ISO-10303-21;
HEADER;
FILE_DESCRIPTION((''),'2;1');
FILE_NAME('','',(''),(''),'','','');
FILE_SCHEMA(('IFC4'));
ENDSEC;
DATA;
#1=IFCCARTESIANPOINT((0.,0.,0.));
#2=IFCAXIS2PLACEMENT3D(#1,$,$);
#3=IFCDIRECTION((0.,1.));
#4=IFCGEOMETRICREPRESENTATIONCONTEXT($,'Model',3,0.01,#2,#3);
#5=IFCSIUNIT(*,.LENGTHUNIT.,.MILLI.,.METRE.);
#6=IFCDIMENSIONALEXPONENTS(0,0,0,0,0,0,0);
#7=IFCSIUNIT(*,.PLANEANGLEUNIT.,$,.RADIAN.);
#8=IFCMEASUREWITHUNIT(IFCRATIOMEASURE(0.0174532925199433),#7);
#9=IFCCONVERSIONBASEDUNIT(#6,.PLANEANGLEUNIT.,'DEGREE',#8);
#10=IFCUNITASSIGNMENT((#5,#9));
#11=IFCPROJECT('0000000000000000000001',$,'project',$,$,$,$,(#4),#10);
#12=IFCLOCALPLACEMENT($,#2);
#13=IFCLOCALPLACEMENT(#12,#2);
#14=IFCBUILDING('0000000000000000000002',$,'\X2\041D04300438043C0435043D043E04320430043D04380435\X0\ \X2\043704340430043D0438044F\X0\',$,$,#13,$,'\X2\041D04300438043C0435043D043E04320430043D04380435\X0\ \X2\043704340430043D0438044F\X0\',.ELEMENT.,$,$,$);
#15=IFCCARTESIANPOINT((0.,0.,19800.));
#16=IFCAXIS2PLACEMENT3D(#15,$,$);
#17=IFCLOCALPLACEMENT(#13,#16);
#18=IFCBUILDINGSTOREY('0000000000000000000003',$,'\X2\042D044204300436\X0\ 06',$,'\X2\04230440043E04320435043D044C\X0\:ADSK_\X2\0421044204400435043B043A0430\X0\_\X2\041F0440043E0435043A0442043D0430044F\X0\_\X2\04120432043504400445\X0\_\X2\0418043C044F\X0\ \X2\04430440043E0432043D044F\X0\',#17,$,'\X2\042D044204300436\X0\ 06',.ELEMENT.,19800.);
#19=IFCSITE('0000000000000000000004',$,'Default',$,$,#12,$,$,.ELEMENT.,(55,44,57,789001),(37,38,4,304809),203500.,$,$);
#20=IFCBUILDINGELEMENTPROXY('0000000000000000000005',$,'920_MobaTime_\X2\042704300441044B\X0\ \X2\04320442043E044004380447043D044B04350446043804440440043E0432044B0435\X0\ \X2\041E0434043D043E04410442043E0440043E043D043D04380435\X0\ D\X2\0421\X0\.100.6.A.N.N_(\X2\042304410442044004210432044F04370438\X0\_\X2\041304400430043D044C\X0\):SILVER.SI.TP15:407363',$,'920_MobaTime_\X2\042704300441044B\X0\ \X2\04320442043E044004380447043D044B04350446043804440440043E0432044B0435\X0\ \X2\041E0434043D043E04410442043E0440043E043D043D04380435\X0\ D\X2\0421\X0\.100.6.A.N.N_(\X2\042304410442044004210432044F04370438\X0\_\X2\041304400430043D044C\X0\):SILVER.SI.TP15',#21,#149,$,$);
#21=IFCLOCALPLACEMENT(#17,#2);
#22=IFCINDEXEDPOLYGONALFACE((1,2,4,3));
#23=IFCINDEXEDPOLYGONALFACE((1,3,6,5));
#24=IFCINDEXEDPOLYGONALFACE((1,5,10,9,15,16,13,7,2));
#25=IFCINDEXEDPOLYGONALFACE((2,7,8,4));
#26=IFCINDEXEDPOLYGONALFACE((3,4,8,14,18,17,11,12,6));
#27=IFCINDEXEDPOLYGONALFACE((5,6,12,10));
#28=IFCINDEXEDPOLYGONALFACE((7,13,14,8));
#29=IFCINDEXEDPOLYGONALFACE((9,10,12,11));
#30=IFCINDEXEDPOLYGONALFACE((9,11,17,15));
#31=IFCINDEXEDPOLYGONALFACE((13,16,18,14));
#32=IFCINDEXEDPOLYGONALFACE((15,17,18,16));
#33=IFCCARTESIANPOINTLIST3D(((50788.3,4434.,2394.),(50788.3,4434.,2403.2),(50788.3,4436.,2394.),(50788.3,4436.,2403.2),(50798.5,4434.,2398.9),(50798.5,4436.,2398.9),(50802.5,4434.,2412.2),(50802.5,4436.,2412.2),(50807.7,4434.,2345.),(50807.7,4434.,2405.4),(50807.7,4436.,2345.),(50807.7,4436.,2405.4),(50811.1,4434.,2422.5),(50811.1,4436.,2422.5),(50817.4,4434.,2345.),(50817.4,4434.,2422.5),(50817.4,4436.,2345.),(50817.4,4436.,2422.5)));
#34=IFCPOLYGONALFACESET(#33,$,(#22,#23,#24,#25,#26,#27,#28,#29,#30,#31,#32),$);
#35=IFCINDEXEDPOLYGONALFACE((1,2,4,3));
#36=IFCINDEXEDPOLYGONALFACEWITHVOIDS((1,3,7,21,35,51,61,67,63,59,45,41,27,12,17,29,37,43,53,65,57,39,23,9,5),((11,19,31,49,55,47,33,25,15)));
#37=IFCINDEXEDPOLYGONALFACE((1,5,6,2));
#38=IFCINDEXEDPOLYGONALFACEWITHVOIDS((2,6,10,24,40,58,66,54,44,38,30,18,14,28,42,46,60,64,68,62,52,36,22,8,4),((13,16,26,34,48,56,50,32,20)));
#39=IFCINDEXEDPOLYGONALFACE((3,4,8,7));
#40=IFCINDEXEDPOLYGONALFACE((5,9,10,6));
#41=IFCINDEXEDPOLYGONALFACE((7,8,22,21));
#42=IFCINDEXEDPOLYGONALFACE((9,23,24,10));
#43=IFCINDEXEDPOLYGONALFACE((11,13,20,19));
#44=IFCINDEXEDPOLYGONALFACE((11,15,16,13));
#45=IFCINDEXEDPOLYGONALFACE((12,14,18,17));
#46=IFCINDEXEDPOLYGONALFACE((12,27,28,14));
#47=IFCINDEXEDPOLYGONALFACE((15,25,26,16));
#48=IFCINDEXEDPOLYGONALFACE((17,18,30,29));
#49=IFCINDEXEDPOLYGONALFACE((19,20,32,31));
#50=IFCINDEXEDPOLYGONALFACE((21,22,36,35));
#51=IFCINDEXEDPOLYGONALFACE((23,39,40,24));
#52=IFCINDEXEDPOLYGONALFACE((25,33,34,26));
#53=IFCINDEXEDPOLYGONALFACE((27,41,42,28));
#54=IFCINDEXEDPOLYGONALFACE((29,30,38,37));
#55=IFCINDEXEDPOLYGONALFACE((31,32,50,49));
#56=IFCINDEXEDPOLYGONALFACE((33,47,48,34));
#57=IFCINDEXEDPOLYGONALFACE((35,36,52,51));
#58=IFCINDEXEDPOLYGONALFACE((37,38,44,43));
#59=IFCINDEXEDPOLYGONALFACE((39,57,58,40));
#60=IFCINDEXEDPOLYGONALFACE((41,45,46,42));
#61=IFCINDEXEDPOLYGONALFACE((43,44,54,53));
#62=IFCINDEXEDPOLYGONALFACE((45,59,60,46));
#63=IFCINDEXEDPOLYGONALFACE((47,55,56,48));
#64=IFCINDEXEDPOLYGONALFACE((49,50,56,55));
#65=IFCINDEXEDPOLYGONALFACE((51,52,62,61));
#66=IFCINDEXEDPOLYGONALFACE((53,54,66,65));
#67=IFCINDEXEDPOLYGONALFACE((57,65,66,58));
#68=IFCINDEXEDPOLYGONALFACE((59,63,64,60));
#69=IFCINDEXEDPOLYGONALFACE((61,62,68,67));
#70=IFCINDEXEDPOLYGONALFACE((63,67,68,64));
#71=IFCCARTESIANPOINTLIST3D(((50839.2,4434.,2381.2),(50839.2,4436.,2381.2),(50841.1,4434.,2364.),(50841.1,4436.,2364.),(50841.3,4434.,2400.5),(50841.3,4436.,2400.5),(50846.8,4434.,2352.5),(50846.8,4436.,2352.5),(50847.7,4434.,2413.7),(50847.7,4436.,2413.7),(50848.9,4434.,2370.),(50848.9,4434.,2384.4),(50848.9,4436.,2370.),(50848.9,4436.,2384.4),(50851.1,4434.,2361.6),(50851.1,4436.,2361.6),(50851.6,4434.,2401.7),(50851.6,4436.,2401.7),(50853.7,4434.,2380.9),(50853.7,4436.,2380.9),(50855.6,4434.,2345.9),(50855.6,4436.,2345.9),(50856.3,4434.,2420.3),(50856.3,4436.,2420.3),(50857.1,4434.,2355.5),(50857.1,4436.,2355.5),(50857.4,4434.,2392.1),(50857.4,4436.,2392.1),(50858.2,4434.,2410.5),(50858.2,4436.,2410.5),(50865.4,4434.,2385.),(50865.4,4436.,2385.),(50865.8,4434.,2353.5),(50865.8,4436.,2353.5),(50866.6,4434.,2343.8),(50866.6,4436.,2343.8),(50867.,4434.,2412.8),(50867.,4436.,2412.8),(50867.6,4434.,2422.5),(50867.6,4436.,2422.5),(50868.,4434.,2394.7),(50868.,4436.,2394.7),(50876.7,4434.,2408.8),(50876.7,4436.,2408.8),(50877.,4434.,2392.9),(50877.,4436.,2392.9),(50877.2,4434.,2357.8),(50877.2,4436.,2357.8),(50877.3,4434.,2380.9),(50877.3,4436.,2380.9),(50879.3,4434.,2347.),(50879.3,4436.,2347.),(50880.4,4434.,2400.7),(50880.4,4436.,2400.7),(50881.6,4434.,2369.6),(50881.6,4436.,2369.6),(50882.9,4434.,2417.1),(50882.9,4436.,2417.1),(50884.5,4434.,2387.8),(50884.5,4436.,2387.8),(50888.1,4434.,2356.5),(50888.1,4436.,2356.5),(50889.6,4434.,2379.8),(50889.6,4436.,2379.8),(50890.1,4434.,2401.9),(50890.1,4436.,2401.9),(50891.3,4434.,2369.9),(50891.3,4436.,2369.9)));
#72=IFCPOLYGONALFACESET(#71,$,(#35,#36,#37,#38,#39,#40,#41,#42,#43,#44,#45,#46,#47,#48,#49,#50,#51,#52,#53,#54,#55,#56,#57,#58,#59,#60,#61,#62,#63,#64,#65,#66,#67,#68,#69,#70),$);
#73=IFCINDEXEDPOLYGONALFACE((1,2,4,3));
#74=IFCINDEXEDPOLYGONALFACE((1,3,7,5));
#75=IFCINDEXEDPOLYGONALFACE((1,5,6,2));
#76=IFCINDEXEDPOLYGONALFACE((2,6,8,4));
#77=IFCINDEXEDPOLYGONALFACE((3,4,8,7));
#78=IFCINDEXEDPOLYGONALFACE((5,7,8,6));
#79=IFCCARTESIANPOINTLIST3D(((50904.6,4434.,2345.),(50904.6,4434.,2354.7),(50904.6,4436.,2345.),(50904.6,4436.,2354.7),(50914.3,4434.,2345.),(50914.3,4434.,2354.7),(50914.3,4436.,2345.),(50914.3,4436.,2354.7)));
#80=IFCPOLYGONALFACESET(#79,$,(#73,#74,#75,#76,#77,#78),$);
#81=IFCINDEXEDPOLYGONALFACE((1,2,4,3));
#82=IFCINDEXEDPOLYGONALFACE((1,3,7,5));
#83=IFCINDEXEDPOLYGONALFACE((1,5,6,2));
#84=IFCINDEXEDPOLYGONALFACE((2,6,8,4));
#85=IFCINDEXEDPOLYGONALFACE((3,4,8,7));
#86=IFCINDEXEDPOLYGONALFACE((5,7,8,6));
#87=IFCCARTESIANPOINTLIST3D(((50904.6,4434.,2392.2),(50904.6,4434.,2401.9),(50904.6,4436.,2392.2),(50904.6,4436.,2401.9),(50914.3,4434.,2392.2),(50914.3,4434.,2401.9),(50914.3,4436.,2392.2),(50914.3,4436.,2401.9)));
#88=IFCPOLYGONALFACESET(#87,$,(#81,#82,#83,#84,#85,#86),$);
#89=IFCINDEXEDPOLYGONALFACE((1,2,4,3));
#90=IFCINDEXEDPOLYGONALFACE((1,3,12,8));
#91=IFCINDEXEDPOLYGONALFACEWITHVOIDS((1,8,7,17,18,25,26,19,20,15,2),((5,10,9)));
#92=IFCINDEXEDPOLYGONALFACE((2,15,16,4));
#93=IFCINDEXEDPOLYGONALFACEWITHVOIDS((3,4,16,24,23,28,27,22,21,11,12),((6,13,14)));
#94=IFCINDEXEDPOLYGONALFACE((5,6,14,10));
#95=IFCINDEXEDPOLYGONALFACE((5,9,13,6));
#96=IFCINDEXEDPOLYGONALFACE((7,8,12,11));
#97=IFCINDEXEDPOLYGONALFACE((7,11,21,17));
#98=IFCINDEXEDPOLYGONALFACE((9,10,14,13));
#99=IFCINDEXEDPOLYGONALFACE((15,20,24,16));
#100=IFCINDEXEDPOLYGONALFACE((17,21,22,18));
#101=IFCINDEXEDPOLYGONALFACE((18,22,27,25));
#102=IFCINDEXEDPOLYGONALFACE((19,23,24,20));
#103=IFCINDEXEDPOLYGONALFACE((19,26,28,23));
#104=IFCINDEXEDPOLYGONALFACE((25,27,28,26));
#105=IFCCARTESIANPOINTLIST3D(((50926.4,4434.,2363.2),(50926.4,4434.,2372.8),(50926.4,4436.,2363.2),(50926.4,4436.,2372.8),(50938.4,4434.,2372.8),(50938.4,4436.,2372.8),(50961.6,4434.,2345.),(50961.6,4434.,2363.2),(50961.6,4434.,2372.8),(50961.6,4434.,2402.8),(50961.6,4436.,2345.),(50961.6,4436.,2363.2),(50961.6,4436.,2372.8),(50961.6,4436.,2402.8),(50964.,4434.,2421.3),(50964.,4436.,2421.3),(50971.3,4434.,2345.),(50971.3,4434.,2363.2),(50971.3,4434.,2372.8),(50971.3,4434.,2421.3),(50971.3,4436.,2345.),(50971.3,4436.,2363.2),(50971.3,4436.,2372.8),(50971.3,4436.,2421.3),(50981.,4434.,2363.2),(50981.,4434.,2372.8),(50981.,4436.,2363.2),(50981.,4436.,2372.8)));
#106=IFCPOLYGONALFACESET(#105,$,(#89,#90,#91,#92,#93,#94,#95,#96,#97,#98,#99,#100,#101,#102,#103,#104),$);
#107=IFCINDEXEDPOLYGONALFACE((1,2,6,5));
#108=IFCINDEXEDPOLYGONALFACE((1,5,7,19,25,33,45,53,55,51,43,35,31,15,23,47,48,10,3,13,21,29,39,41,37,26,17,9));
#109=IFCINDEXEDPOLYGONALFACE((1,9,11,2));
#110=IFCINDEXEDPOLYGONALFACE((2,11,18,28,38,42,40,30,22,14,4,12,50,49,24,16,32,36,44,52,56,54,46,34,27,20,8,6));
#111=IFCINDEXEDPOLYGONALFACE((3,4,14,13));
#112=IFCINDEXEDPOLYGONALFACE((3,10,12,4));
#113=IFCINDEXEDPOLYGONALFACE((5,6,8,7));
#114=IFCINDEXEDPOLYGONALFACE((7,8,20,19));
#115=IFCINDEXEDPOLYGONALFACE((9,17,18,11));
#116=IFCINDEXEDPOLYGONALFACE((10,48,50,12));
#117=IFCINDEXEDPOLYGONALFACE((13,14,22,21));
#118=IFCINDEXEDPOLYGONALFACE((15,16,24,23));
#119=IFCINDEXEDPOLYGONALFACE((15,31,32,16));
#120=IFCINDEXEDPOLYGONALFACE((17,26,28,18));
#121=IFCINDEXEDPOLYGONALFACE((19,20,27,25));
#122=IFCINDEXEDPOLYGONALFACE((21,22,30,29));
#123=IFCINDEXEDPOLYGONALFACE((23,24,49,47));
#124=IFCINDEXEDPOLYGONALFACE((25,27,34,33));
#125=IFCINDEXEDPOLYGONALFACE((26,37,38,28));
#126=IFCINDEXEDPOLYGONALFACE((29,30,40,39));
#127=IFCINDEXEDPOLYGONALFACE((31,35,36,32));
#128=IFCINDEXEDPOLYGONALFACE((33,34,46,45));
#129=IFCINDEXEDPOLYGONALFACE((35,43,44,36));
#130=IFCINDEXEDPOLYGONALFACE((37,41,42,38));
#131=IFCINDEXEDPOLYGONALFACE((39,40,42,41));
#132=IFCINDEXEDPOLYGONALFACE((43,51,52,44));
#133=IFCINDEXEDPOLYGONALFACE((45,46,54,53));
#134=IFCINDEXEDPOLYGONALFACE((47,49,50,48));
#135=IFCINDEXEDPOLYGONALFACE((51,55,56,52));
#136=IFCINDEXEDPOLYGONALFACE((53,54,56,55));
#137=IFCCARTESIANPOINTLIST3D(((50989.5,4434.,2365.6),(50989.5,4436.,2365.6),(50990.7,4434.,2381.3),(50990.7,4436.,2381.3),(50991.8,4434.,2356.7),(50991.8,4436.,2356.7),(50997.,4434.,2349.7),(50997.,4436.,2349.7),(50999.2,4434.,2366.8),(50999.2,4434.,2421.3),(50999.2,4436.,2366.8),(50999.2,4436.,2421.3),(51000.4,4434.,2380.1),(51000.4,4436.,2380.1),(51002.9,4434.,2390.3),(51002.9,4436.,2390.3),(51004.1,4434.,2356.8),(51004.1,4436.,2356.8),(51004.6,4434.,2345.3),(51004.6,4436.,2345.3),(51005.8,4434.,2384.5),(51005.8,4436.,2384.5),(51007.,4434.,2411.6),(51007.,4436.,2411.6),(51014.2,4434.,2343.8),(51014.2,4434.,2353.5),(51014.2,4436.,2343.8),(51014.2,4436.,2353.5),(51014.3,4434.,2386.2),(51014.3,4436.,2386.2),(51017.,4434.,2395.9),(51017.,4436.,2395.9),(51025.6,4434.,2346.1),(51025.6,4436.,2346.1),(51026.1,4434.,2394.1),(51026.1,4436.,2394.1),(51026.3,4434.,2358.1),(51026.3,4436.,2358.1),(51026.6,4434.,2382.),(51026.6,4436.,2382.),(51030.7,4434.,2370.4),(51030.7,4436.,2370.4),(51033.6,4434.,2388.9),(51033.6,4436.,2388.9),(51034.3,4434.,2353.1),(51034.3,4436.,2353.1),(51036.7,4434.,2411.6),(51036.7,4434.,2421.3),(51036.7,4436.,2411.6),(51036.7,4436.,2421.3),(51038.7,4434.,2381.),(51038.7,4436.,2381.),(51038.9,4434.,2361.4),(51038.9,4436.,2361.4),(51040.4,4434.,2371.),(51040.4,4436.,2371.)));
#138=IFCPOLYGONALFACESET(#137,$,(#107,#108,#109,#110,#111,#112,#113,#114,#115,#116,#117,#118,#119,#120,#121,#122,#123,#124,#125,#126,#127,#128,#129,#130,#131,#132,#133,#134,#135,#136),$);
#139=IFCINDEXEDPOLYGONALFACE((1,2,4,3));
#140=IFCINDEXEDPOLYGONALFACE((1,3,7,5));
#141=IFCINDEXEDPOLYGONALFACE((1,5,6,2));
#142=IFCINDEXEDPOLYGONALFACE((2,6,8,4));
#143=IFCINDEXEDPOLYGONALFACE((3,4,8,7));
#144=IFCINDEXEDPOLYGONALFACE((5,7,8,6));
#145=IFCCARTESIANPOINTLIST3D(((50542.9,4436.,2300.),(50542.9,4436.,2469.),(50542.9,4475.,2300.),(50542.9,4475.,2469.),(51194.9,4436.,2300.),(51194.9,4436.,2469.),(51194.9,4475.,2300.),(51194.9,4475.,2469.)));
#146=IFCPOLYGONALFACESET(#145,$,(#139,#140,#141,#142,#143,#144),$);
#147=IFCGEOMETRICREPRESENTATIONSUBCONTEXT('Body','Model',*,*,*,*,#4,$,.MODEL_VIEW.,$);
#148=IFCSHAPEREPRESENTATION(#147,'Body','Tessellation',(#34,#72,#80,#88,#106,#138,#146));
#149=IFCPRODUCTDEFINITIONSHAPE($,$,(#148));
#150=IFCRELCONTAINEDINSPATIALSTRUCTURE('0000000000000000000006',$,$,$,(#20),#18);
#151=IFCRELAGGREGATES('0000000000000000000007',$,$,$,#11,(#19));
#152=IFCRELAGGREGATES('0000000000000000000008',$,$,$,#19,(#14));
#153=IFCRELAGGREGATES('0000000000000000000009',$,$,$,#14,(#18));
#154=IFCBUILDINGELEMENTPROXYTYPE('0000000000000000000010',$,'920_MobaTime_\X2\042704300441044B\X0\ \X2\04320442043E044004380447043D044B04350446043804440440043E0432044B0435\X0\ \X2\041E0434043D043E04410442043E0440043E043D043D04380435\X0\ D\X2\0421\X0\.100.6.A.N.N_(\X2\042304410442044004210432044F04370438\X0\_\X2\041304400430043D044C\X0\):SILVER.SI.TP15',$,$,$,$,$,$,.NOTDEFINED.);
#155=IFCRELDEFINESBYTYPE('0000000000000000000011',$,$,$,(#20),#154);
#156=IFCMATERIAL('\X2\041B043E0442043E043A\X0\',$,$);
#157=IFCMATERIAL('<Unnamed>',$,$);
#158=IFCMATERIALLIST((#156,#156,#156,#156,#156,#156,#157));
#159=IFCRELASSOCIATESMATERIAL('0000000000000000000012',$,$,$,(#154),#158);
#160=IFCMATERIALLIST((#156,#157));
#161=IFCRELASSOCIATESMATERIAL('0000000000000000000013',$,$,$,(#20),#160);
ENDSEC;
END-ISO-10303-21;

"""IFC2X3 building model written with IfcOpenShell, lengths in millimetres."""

from ifc_helpers import new_model, entity, si_unit, converted_unit, direction, frame, origin, origin_2d_with_axis, place, context, subcontext, project, spatial, polyline, rectangle, outline, extrude, source, transform, mapped, material, material_list, type_object, type_shapes, element, save


model = new_model("IFC2X3")

# Units and contexts
model_context = context("Model", 3, precision=0.01, world=origin(), true_north=direction((0.0, 1.0)))
body_context = subcontext(model_context, "Body", "Model", "MODEL_VIEW")
ifc_project = project(units=[si_unit("LENGTHUNIT", "METRE", prefix="MILLI"), converted_unit("PLANEANGLEUNIT", "DEGREE", entity("IfcRatioMeasure", 0.0174532925199433), si_unit("PLANEANGLEUNIT", "RADIAN"), dimensions=[0, 0, 0, 0, 0, 0, 0])], contexts=[model_context])

# Site, building, storey
site_placement = place(None, frame((0.0, 0.0, 0.0)))
site = spatial("IfcSite", under=ifc_project, at=site_placement, Name="Default", CompositionType="ELEMENT", RefLatitude=(55, 44, 57, 789001), RefLongitude=(37, 38, 4, 304809), RefElevation=203500.0)
building_placement = place(site_placement, origin())
building = spatial("IfcBuilding", under=site, at=building_placement, Name="Наименование здания", LongName="Наименование здания", CompositionType="ELEMENT")
storey_placement = place(building_placement, frame((0.0, 0.0, 19800.0)))
storey = spatial("IfcBuildingStorey", under=building, at=storey_placement, Name="Этаж 06", ObjectType="Уровень:ADSK_Стрелка_Проектная_Вверх_Имя уровня", LongName="Этаж 06", CompositionType="ELEMENT", Elevation=19800.0)

# Building element proxy
ifc_material_1 = material(Name="Лоток")
ifc_material_2 = material(Name="<Unnamed>")
ifc_material_list_1 = material_list([ifc_material_1, ifc_material_2])
ifc_material_list_2 = material_list([ifc_material_1, ifc_material_1, ifc_material_1, ifc_material_1, ifc_material_1, ifc_material_1, ifc_material_2])
building_element_proxy_type_1 = type_object("IfcBuildingElementProxyType", Name="920_MobaTime_Часы вторичныецифровые Односторонние DС.100.6.A.N.N_(УстрСвязи_Грань):SILVER.SI.TP15", PredefinedType="NOTDEFINED", material=ifc_material_list_2)
shared_shape_1 = source(origin(), body_context, "Body", "SweptSolid", [
    extrude(outline(polyline([(-49.3, -13.1), (28.2, -13.1), (28.2, -6.8), (17.9, 1.8), (8.9, 16.0), (-0.3, 16.0), (4.6, 5.8), (11.1, -3.4), (-49.3, -3.4), (-49.3, -13.1)])), frame((-64.6, 9.8, 39.0), z_axis=(0.0, 0.0, 1.0), x_axis=(0.0, 1.0, 0.0)), (0.0, 0.0, 1.0), 2.0),
    extrude(outline(polyline([(2.2, -27.6), (19.0, -27.6), (30.5, -16.1), (33.3, -4.9), (31.0, 5.8), (21.8, 17.2), (5.2, 27.3), (-11.1, 33.0), (-24.0, 32.7), (-33.6, 27.6), (-40.3, 18.6), (-42.8, 5.7), (-38.0, -6.3), (-27.2, -15.0), (-17.5, -17.7), (-8.2, -16.4), (-0.3, -11.9), (5.1, -4.5), (7.3, 6.2), (4.0, 17.2), (18.5, 7.3), (23.6, -2.4), (22.0, -11.4), (14.2, -18.4), (5.3, -18.3), (2.2, -27.6)]), holes=[polyline([(-9.0, 23.3), (-1.3, 14.4), (-2.6, 2.0), (-11.4, -7.0), (-23.4, -6.1), (-32.2, 2.9), (-31.2, 15.1), (-25.6, 22.1), (-17.5, 24.9), (-9.0, 23.3)])]), frame((-2.7, 3.6, 39.0), z_axis=(0.0, 0.0, 1.0), x_axis=(-0.427649, 0.903945, 0.0)), (0.0, 0.0, 1.0), 2.0),
    extrude(rectangle(XDim=9.7, YDim=9.7, at=origin_2d_with_axis()), frame((40.6, -34.7, 39.0)), (0.0, 0.0, 1.0), 2.0),
    extrude(rectangle(XDim=9.7, YDim=9.7, at=origin_2d_with_axis()), frame((40.6, 12.6, 39.0)), (0.0, 0.0, 1.0), 2.0),
    extrude(outline(polyline([(-0.9, -28.1), (8.8, -28.1), (8.8, -9.9), (18.5, -9.9), (18.5, -0.2), (8.8, -0.2), (8.8, 48.3), (1.5, 48.3), (-36.0, -0.2), (-36.0, -9.9), (-0.9, -9.9), (-0.9, -28.1)]), holes=[polyline([(-0.9, -0.2), (-24.1, -0.2), (-0.9, 29.7), (-0.9, -0.2)])]), frame((93.6, -11.4, 39.0)), (0.0, 0.0, 1.0), 2.0),
    extrude(outline(polyline([(3.3, -28.3), (12.5, -28.3), (20.5, -25.0), (26.8, -18.8), (30.7, -10.0), (31.4, 1.6), (26.9, 11.8), (20.1, 18.4), (11.1, 22.3), (1.0, 23.3), (-7.9, 20.4), (-14.9, 14.5), (-18.9, 6.2), (-17.1, -9.0), (-36.7, 0.5), (-29.1, 29.3), (-38.5, 31.7), (-48.1, -4.6), (-11.6, -23.0), (-8.0, -14.0), (-10.8, -7.6), (-10.2, 1.1), (-3.0, 11.8), (9.2, 12.8), (20.0, 5.4), (21.3, -7.5), (15.5, -16.4), (4.6, -18.6), (3.3, -28.3)])), frame((147.1, -8.5, 39.0), z_axis=(0.0, 0.0, 1.0), x_axis=(0.256974, -0.966418, 0.0)), (0.0, 0.0, 1.0), 2.0),
    extrude(rectangle(XDim=652.0, YDim=169.0, at=origin_2d_with_axis()), frame((0.0, 0.0, 0.0), z_axis=(0.0, 0.0, 1.0), x_axis=(-1.0, 0.0, 0.0)), (0.0, 0.0, 1.0), 39.0),
])
type_shapes(building_element_proxy_type_1, [shared_shape_1])
proxy_1_placement = place(storey_placement, frame((50868.9, 4475.0, 2384.5), z_axis=(0.0, -1.0, 0.0), x_axis=(1.0, 0.0, 0.0)))
element("IfcBuildingElementProxy", 1, at=proxy_1_placement, inside=storey, type_object=building_element_proxy_type_1, material=ifc_material_list_1, Name="920_MobaTime_Часы вторичныецифровые Односторонние DС.100.6.A.N.N_(УстрСвязи_Грань):SILVER.SI.TP15:407363", ObjectType="920_MobaTime_Часы вторичныецифровые Односторонние DС.100.6.A.N.N_(УстрСвязи_Грань):SILVER.SI.TP15", context=body_context, shape_type="MappedRepresentation", body=[
    mapped(shared_shape_1, transform((0.0, 0.0, 0.0), scale=1.0)),
])

save(model, "model.ifc")
